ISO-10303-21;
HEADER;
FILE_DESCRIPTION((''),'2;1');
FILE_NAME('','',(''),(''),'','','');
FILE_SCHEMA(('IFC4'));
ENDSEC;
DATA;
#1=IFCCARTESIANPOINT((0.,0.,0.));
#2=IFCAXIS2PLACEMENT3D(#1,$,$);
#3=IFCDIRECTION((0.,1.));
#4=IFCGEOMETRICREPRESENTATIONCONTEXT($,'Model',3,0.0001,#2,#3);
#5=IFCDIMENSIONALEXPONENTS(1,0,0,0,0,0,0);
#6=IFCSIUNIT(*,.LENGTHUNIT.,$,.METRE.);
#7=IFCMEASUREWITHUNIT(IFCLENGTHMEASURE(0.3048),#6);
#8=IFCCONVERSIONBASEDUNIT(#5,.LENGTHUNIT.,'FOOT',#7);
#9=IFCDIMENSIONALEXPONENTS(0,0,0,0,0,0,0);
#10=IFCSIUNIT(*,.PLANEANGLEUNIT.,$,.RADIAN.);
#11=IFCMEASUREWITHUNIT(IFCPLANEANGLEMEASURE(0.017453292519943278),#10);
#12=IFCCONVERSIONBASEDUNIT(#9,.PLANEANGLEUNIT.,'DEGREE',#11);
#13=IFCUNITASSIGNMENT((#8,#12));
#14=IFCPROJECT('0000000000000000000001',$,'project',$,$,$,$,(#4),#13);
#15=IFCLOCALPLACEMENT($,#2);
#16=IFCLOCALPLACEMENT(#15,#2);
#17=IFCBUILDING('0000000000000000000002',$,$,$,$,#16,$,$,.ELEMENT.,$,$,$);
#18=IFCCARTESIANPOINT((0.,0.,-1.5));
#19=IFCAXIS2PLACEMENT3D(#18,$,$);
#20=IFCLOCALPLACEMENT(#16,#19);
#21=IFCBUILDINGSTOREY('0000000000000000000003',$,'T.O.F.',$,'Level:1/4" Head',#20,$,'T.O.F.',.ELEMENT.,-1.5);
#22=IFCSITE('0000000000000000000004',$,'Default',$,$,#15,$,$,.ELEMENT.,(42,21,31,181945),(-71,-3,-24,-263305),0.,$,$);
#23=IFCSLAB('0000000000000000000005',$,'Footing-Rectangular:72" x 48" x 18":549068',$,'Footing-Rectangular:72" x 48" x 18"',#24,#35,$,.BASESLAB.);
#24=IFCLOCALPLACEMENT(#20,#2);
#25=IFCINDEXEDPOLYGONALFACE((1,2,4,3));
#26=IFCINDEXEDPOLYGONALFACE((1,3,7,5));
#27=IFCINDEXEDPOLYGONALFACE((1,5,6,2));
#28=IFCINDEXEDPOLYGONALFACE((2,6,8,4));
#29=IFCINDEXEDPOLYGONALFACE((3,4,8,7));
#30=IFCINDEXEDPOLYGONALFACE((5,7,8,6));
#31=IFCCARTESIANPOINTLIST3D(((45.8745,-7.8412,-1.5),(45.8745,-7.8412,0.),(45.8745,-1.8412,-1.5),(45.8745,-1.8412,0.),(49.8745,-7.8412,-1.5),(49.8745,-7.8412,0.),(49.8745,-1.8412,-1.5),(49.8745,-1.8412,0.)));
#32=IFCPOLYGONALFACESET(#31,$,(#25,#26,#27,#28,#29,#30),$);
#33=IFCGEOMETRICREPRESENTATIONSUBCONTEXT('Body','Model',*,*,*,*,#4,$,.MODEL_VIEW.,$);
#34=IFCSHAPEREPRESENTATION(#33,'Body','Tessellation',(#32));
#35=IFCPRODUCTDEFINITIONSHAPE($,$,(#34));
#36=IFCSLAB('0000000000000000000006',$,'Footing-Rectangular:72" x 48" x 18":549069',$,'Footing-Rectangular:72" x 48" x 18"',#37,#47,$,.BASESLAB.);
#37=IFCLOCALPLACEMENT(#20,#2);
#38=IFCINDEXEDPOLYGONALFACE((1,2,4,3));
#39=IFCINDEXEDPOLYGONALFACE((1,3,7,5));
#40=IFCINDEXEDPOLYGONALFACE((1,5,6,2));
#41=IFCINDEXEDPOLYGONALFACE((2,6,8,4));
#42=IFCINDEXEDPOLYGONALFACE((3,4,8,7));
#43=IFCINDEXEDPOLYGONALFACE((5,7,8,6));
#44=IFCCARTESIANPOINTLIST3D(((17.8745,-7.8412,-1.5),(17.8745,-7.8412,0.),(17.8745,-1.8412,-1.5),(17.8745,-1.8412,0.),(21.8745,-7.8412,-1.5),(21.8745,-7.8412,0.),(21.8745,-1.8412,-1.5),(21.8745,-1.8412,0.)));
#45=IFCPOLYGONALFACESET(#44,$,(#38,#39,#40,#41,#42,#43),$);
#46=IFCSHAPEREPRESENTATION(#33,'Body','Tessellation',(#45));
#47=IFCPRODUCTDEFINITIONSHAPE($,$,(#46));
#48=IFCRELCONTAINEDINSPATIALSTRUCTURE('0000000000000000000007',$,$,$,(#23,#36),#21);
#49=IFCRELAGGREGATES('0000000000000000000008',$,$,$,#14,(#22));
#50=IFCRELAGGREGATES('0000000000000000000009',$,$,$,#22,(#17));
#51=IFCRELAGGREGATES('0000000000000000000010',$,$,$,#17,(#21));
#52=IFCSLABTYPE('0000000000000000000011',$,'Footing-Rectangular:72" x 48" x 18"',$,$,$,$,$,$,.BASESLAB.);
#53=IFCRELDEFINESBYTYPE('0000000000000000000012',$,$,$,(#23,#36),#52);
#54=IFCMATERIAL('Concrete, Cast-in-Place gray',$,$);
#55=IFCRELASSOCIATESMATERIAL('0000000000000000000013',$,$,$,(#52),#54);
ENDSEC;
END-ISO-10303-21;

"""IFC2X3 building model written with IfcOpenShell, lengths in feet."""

from ifc_helpers import new_model, entity, si_unit, converted_unit, direction, frame, frame_2d, origin, place, context, subcontext, project, spatial, rectangle, extrude, material, type_object, element, save


model = new_model("IFC2X3")

# Units and contexts
model_context = context("Model", 3, precision=0.0001, world=origin(), true_north=direction((0.0, 1.0)))
body_context = subcontext(model_context, "Body", "Model", "MODEL_VIEW")
ifc_project = project(units=[converted_unit("LENGTHUNIT", "FOOT", entity("IfcLengthMeasure", 0.3048), si_unit("LENGTHUNIT", "METRE"), dimensions=[1, 0, 0, 0, 0, 0, 0]), converted_unit("PLANEANGLEUNIT", "DEGREE", entity("IfcPlaneAngleMeasure", 0.017453292519943278), si_unit("PLANEANGLEUNIT", "RADIAN"), dimensions=[0, 0, 0, 0, 0, 0, 0])], contexts=[model_context])

# Site, building, storey
site_placement = place(None, origin())
site = spatial("IfcSite", under=ifc_project, at=site_placement, Name="Default", CompositionType="ELEMENT", RefLatitude=(42, 21, 31, 181945), RefLongitude=(-71, -3, -24, -263305), RefElevation=0.0)
building_placement = place(site_placement, origin())
building = spatial("IfcBuilding", under=site, at=building_placement, CompositionType="ELEMENT")
storey_placement = place(building_placement, frame((0.0, 0.0, -1.5)))
storey = spatial("IfcBuildingStorey", under=building, at=storey_placement, Name="T.O.F.", ObjectType="Level:1/4\" Head", LongName="T.O.F.", CompositionType="ELEMENT", Elevation=-1.5)

# Slabs
ifc_material = material(Name="Concrete, Cast-in-Place gray")
slab_type = type_object("IfcSlabType", Name="Footing-Rectangular:72\" x 48\" x 18\"", PredefinedType="BASESLAB", material=ifc_material)
slab_1_placement = place(storey_placement, origin())
element("IfcSlab", 1, at=slab_1_placement, inside=storey, type_object=slab_type, Name="Footing-Rectangular:72\" x 48\" x 18\":549068", ObjectType="Footing-Rectangular:72\" x 48\" x 18\"", PredefinedType="BASESLAB", context=body_context, shape_type="SweptSolid", body=[
    extrude(rectangle(XDim=4.0, YDim=6.0, at=frame_2d((0.0, 0.0), x_axis=(1.0, 0.0))), frame((47.8745, -4.8412, -1.5), z_axis=(0.0, 0.0, 1.0), x_axis=(-1.0, 0.0, 0.0)), (0.0, 0.0, 1.0), 1.5),
])
slab_2_placement = place(storey_placement, origin())
element("IfcSlab", 2, at=slab_2_placement, inside=storey, type_object=slab_type, Name="Footing-Rectangular:72\" x 48\" x 18\":549069", ObjectType="Footing-Rectangular:72\" x 48\" x 18\"", PredefinedType="BASESLAB", context=body_context, shape_type="SweptSolid", body=[
    extrude(rectangle(XDim=4.0, YDim=6.0, at=frame_2d((0.0, 0.0), x_axis=(1.0, 0.0))), frame((19.8745, -4.8412, -1.5), z_axis=(0.0, 0.0, 1.0), x_axis=(-1.0, 0.0, 0.0)), (0.0, 0.0, 1.0), 1.5),
])

save(model, "model.ifc")
